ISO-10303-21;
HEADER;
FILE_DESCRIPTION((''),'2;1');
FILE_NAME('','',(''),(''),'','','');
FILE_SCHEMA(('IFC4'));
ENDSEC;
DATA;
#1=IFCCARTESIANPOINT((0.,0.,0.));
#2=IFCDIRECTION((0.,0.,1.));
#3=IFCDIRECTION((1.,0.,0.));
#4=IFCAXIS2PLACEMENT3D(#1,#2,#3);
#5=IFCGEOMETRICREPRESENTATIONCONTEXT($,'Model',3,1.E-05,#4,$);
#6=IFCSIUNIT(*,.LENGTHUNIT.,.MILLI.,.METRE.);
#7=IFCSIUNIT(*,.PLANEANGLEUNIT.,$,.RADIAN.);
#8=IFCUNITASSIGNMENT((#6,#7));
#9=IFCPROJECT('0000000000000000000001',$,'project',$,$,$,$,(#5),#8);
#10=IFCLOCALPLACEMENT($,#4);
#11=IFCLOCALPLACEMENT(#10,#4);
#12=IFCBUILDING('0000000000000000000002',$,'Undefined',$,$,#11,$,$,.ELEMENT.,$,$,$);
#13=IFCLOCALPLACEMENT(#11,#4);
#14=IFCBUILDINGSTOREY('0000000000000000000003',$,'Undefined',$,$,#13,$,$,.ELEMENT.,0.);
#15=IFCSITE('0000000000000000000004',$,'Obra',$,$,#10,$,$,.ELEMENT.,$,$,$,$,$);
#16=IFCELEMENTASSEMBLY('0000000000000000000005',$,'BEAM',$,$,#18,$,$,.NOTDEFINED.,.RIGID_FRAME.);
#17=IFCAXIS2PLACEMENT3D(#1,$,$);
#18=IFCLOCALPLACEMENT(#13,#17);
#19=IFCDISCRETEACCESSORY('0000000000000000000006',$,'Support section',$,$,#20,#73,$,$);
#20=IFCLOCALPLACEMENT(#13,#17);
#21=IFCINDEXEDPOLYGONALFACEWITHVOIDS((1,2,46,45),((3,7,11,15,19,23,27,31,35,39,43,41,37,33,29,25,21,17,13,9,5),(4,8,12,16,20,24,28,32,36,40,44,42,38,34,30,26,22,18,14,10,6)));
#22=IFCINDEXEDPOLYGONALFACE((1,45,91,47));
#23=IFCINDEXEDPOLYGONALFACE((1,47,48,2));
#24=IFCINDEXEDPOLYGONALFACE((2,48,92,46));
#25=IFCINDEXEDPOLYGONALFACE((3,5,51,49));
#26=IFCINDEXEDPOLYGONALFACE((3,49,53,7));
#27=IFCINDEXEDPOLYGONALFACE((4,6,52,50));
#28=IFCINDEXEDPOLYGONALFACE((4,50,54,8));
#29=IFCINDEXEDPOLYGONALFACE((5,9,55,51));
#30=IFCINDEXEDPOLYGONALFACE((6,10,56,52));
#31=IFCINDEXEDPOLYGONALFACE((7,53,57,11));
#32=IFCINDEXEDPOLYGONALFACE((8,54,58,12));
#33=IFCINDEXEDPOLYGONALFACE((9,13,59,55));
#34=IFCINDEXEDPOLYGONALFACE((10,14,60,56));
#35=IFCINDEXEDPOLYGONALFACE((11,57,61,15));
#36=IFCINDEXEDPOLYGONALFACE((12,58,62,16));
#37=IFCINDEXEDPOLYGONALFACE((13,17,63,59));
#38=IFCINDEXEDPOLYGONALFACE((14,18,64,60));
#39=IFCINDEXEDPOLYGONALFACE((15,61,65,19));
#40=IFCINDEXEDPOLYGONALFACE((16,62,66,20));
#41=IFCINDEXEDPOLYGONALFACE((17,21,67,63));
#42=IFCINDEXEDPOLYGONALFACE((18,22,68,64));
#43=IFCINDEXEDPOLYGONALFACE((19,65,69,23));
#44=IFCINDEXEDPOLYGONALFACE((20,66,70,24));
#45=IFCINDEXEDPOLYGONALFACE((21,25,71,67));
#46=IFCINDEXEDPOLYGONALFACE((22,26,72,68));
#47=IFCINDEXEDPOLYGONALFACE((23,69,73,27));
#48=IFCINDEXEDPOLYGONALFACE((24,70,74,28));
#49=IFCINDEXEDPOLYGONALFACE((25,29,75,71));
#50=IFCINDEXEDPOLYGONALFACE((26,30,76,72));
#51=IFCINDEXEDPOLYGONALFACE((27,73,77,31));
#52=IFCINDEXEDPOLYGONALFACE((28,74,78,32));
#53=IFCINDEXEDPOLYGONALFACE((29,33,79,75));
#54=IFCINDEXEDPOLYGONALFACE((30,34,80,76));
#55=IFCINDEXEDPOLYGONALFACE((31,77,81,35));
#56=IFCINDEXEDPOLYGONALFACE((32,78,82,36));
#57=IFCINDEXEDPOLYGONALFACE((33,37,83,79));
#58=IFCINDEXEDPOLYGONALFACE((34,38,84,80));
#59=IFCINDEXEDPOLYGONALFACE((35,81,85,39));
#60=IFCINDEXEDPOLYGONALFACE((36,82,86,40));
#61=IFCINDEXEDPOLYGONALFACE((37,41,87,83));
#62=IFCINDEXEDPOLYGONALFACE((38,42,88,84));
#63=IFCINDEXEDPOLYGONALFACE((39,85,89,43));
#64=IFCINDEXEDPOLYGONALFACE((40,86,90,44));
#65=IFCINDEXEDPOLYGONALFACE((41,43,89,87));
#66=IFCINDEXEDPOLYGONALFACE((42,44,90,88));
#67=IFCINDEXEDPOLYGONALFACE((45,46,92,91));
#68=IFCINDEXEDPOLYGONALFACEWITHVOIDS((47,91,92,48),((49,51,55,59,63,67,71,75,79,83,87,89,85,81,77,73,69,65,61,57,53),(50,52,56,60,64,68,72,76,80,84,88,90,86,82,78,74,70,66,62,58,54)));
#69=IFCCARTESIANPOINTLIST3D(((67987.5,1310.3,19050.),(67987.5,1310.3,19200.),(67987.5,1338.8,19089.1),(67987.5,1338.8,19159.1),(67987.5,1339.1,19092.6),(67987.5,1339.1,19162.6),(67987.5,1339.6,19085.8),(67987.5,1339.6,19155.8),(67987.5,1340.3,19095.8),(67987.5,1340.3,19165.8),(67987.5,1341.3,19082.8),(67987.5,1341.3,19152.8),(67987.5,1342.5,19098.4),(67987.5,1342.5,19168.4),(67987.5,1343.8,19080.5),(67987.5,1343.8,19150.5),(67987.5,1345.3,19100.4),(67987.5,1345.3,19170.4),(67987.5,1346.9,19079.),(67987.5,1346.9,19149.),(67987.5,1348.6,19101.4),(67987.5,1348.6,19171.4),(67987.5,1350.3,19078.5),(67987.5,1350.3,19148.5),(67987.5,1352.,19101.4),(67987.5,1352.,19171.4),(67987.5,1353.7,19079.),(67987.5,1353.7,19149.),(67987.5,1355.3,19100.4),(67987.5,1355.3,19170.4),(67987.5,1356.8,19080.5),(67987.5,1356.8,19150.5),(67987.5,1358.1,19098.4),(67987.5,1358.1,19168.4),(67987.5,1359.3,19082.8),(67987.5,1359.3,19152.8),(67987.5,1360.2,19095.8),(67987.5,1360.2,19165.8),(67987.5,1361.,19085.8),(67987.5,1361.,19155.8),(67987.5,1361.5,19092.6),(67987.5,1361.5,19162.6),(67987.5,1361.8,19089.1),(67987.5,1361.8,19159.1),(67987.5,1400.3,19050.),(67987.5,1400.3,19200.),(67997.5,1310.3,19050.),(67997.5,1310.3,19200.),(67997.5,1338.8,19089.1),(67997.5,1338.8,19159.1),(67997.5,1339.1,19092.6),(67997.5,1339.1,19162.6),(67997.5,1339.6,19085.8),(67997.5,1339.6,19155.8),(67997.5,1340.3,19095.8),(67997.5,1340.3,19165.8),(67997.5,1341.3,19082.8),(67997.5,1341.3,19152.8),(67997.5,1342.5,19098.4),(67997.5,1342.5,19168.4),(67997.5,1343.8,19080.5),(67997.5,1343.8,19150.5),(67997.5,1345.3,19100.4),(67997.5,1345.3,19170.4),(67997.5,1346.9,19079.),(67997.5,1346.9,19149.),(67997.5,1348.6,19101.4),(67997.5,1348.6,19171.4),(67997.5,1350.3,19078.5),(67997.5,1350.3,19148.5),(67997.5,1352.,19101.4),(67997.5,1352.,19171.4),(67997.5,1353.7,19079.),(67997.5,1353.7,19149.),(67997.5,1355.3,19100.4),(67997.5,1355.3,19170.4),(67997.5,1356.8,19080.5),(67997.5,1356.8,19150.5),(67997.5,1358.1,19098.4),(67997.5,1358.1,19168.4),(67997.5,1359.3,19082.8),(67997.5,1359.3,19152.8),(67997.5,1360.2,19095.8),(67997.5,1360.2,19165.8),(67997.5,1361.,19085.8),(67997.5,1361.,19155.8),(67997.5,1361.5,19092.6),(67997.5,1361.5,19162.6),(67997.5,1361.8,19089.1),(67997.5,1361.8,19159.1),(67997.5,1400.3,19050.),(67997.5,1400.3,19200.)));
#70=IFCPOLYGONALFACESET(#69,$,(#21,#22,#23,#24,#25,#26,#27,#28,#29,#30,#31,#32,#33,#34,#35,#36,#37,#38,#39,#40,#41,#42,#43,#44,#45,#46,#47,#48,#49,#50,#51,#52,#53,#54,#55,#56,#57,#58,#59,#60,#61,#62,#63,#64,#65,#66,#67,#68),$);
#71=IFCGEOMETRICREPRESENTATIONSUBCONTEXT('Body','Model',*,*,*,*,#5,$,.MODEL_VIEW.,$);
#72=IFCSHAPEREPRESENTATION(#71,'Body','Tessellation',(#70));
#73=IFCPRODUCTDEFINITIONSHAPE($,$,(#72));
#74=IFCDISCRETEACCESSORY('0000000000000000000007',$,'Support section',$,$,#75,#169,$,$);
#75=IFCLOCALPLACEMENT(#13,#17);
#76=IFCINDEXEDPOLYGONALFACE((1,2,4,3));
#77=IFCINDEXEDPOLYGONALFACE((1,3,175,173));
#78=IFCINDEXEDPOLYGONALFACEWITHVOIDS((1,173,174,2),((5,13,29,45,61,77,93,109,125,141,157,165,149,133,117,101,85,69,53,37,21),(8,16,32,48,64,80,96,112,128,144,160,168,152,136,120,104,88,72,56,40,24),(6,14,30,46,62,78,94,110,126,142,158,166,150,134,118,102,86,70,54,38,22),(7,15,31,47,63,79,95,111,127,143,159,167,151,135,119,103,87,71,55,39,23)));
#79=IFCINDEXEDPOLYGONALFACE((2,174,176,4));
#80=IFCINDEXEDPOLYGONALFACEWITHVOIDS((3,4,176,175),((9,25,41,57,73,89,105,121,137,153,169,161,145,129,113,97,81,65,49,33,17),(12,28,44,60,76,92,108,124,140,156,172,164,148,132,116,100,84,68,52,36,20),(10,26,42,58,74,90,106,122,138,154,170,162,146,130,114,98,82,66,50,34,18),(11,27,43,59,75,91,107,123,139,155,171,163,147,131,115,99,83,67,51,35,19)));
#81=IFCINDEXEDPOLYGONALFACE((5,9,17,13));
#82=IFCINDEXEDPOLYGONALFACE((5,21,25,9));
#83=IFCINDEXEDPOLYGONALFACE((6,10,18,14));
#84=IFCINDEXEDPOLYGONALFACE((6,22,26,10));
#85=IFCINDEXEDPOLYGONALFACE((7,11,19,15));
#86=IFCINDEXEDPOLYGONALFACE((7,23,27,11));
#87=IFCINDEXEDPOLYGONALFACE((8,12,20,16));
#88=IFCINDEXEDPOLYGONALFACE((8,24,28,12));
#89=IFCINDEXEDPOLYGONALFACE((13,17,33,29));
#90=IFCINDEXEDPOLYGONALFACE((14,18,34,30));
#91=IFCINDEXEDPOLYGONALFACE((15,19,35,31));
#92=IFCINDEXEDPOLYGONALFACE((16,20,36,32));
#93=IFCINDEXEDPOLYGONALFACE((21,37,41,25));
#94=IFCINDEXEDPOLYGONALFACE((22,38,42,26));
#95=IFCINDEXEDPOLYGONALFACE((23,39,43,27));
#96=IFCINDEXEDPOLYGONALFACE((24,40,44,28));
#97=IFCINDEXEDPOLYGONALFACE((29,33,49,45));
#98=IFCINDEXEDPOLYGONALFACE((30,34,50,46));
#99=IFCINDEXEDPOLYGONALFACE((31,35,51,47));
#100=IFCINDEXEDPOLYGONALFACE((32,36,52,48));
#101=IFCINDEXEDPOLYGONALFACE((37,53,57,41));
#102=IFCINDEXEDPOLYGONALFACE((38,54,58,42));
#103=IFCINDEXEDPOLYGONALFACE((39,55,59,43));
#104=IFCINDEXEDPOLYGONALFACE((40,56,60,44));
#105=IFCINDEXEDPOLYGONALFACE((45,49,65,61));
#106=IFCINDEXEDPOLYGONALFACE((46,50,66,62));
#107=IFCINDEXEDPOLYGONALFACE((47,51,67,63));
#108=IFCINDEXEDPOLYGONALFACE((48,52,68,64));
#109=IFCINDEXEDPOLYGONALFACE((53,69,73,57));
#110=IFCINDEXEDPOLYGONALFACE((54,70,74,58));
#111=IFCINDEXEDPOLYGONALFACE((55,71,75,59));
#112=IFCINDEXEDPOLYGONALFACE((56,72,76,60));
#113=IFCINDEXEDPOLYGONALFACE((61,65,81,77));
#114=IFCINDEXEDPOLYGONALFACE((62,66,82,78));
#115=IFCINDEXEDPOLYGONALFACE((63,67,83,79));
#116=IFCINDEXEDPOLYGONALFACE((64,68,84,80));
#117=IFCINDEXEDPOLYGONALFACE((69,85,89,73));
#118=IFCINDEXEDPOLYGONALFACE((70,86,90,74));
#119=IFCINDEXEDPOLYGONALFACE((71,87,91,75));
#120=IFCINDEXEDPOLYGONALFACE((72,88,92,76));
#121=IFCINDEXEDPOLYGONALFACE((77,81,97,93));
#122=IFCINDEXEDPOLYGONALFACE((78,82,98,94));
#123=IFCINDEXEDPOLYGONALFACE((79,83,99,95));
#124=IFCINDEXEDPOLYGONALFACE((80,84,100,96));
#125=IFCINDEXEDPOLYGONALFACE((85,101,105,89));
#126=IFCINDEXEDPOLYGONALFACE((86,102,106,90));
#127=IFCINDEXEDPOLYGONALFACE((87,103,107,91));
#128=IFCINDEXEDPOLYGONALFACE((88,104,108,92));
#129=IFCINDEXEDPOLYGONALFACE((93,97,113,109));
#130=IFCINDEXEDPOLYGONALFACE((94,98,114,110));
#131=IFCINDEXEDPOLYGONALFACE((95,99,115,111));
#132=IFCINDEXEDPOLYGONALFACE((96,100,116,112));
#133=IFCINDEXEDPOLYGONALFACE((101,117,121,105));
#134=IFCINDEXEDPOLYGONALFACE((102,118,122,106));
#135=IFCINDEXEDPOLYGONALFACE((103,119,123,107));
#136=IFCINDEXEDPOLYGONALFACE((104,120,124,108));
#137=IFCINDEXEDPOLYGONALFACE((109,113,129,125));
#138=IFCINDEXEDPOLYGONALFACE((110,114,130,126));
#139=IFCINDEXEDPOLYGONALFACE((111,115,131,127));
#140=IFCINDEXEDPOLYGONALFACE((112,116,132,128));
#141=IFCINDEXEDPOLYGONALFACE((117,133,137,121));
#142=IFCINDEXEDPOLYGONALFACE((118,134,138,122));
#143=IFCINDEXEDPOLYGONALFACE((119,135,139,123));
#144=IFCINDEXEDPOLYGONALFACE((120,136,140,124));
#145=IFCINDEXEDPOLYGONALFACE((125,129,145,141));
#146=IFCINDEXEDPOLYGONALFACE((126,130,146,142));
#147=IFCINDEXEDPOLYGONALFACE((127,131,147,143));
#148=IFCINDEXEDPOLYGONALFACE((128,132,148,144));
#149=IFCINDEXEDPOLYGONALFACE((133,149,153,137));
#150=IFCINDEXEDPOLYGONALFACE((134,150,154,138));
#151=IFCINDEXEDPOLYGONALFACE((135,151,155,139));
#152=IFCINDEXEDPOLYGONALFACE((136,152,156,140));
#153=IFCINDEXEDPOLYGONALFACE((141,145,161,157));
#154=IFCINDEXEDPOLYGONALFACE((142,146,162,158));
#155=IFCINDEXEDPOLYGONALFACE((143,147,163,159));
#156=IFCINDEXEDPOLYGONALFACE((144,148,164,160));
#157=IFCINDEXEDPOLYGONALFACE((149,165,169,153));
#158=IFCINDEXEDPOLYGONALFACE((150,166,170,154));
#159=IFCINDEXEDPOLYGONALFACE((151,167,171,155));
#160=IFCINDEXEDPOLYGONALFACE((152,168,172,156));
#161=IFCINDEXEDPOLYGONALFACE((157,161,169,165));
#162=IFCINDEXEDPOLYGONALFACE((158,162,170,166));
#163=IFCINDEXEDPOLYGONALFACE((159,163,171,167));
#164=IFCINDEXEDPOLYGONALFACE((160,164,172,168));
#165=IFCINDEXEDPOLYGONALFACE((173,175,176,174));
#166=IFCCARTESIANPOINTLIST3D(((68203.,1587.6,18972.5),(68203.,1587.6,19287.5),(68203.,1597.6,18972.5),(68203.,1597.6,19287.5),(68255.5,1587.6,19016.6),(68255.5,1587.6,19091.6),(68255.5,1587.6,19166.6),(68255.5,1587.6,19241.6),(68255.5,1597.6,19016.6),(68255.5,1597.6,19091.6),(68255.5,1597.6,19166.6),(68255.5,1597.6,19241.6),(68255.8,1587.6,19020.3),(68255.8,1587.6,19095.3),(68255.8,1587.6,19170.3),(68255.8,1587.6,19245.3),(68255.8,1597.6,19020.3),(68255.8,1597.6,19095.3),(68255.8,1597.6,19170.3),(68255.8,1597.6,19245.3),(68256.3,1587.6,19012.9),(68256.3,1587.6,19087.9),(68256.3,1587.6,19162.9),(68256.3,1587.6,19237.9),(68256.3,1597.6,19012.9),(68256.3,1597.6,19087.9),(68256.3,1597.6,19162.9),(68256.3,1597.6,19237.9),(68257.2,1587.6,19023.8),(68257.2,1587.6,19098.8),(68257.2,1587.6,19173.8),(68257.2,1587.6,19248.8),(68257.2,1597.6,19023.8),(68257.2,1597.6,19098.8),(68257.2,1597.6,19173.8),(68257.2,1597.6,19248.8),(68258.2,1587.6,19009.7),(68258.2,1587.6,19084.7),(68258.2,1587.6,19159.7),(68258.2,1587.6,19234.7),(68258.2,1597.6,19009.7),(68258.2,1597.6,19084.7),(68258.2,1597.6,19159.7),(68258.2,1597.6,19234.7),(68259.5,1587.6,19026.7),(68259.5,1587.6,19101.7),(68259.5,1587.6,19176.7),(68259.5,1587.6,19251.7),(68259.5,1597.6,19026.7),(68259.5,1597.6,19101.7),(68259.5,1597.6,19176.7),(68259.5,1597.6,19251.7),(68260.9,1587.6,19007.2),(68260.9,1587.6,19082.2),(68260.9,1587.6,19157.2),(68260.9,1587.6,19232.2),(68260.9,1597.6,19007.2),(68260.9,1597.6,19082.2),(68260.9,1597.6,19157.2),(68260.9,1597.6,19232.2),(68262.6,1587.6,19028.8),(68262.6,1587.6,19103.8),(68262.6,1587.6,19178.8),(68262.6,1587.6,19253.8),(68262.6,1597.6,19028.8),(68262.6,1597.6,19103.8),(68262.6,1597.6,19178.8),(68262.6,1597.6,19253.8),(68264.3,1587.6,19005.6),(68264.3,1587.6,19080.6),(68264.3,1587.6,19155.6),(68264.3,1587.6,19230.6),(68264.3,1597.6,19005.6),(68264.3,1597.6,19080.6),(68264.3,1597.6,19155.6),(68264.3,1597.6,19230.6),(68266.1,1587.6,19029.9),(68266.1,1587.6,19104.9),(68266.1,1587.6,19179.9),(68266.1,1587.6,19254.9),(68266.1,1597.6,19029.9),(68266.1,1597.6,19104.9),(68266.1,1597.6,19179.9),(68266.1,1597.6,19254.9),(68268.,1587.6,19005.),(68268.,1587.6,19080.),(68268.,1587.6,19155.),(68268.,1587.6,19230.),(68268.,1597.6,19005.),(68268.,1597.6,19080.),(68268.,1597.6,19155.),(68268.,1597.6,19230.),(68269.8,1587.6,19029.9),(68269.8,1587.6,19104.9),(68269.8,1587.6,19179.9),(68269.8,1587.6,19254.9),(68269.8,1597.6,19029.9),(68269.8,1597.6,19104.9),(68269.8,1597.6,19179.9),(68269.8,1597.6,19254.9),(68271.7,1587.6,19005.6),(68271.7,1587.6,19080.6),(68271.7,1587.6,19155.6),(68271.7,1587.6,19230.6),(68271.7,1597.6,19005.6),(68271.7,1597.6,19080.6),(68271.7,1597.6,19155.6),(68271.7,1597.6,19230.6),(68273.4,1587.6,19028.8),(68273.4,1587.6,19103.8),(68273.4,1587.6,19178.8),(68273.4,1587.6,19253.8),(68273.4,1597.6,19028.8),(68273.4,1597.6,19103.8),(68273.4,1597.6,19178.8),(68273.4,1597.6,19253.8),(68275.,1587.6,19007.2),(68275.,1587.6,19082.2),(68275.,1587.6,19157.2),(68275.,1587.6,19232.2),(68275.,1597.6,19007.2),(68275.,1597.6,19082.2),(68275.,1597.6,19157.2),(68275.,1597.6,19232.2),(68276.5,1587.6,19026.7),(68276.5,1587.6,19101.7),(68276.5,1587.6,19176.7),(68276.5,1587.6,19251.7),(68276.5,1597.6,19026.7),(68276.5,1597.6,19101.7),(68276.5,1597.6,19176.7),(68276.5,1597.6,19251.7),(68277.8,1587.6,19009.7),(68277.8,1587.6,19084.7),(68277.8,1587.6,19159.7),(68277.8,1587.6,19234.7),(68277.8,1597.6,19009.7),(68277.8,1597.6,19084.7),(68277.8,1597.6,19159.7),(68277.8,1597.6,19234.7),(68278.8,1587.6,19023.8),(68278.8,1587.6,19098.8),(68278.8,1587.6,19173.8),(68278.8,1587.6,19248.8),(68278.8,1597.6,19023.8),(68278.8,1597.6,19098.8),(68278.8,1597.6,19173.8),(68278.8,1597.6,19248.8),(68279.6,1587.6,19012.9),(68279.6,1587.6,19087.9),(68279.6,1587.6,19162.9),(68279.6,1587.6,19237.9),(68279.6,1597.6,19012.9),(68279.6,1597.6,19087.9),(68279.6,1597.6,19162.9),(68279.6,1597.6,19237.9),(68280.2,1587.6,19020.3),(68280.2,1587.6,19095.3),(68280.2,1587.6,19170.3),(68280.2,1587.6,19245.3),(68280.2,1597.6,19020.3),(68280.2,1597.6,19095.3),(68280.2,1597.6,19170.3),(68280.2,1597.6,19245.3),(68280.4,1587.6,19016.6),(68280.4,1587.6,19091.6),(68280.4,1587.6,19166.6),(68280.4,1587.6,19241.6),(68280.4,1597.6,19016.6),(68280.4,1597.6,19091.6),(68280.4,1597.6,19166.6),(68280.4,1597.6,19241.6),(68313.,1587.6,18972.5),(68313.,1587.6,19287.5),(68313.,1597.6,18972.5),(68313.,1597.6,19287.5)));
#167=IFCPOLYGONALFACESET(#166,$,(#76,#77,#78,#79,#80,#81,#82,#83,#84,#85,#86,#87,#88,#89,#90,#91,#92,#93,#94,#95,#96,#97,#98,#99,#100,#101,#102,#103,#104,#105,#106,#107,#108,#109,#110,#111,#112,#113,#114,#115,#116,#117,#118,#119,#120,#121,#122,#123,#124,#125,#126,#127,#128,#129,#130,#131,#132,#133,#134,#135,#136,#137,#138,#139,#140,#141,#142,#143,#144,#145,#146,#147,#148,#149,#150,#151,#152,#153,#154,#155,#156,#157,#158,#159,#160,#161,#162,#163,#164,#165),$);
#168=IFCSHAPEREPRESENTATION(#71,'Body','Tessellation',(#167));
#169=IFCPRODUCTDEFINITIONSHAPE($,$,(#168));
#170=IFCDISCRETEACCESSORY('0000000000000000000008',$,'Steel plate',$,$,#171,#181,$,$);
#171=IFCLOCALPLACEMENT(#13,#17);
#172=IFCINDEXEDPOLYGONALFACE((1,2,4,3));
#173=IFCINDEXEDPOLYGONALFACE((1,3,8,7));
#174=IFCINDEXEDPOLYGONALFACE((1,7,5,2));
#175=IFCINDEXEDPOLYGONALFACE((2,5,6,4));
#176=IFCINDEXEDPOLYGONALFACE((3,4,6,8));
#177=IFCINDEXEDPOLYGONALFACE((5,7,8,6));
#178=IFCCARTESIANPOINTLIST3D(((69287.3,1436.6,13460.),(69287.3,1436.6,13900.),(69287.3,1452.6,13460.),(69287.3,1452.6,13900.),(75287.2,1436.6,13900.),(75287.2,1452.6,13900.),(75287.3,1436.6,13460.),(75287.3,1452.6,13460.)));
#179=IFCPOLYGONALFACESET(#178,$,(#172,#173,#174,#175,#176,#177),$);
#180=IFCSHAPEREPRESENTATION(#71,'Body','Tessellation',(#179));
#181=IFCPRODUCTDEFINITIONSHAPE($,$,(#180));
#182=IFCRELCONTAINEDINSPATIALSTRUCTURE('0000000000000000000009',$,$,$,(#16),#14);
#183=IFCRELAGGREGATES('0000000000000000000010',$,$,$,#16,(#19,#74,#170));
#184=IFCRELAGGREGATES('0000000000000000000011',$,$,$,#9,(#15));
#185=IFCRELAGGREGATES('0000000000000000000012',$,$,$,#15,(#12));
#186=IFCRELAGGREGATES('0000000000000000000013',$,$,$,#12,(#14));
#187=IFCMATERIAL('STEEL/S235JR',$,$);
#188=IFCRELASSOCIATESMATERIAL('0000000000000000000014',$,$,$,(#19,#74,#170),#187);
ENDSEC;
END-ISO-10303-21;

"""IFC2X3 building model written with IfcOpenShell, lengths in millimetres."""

from ifc_helpers import new_model, si_unit, frame, origin_with_axes, origin_2d_with_axis, place, context, subcontext, project, spatial, polyline, rectangle, circle, outline, extrude, source, transform, mapped, material, element, aggregate, save


model = new_model("IFC2X3")

# Units and contexts
model_context = context("Model", 3, precision=1e-05, world=origin_with_axes())
body_context = subcontext(model_context, "Body", "Model", "MODEL_VIEW")
ifc_project = project(units=[si_unit("LENGTHUNIT", "METRE", prefix="MILLI"), si_unit("PLANEANGLEUNIT", "RADIAN")], contexts=[model_context])

# Site, building, storey
site_placement = place(None, origin_with_axes())
site = spatial("IfcSite", under=ifc_project, at=site_placement, Name="Obra", CompositionType="ELEMENT")
building_placement = place(site_placement, origin_with_axes())
building = spatial("IfcBuilding", under=site, at=building_placement, Name="Undefined", CompositionType="ELEMENT")
storey_placement = place(building_placement, origin_with_axes())
storey = spatial("IfcBuildingStorey", under=building, at=storey_placement, Name="Undefined", CompositionType="ELEMENT", Elevation=0.0)

# Element assembly
assembly_1_placement = place(storey_placement, origin_with_axes())
assembly_1 = element("IfcElementAssembly", 1, at=assembly_1_placement, inside=storey, Name="BEAM", AssemblyPlace="NOTDEFINED", PredefinedType="RIGID_FRAME")

# Shared definitions
ifc_material_1 = material(Name="STEEL/S235JR")

# Discrete accessories, openings
shared_shape_1 = source(origin_with_axes(), body_context, "Body", "SweptSolid", [
    extrude(circle(Radius=11.5, at=origin_2d_with_axis()), frame((0.0, -12.6, 0.0), z_axis=(0.0, 1.0, 0.0), x_axis=(1.0, 0.0, 0.0)), (0.0, 0.0, 1.0), 10.2),
])
discrete_accessory_1_placement = place(assembly_1_placement, frame((67992.5, 1355.3, 19050.0), z_axis=(0.0, 0.0, 1.0), x_axis=(0.0, 1.0, 0.0)))
discrete_accessory_1 = element("IfcDiscreteAccessory", 2, at=discrete_accessory_1_placement, material=ifc_material_1, Name="Support section", context=body_context, shape_type="SweptSolid", body=[
    extrude(rectangle(XDim=10.0, YDim=90.0, at=origin_2d_with_axis()), frame((0.0, 0.0, 150.0), z_axis=(0.0, 0.0, -1.0), x_axis=(0.0, 1.0, 0.0)), (0.0, 0.0, 1.0), 150.0),
])
opening_1_placement = place(assembly_1_placement, frame((68000.0, 1390.3, 19205.0), z_axis=(0.0, -1.0, 0.0), x_axis=(0.0, 0.0, -1.0)))
element("IfcOpeningElement", 3, at=opening_1_placement, cuts=discrete_accessory_1, ObjectType="Opening", context=body_context, shape_type="MappedRepresentation", body=[
    mapped(shared_shape_1, transform((45.0, 0.0, 40.0))),
    mapped(shared_shape_1, transform((115.0, 0.0, 40.0))),
])
discrete_accessory_2_placement = place(assembly_1_placement, frame((68258.0, 1592.6, 18972.5), z_axis=(0.0, 0.0, 1.0), x_axis=(-1.0, 0.0, 0.0)))
discrete_accessory_2 = element("IfcDiscreteAccessory", 4, at=discrete_accessory_2_placement, material=ifc_material_1, Name="Support section", context=body_context, shape_type="SweptSolid", body=[
    extrude(rectangle(XDim=10.0, YDim=110.0, at=origin_2d_with_axis()), frame((0.0, 0.0, 315.0), z_axis=(0.0, 0.0, -1.0), x_axis=(0.0, 1.0, 0.0)), (0.0, 0.0, 1.0), 315.0),
])
shared_shape_2 = source(origin_with_axes(), body_context, "Body", "SweptSolid", [
    extrude(circle(Radius=12.5, at=origin_2d_with_axis()), frame((0.0, -15.8, 0.0), z_axis=(0.0, 1.0, 0.0), x_axis=(1.0, 0.0, 0.0)), (0.0, 0.0, 1.0), 10.2),
])
opening_2_placement = place(assembly_1_placement, frame((68223.0, 1603.4, 19350.0), z_axis=(1.0, 0.0, 0.0), x_axis=(0.0, 0.0, -1.0)))
element("IfcOpeningElement", 5, at=opening_2_placement, cuts=discrete_accessory_2, ObjectType="Opening", context=body_context, shape_type="MappedRepresentation", body=[
    mapped(shared_shape_2, transform((107.5, 0.0, 45.0))),
    mapped(shared_shape_2, transform((182.5, 0.0, 45.0))),
    mapped(shared_shape_2, transform((257.5, 0.0, 45.0))),
    mapped(shared_shape_2, transform((332.5, 0.0, 45.0))),
])

# Discrete accessory
discrete_accessory_3_placement = place(assembly_1_placement, frame((69287.3, 1444.6, 13900.0), z_axis=(0.0, -1.0, 0.0), x_axis=(0.0, 0.0, -1.0)))
discrete_accessory_3 = element("IfcDiscreteAccessory", 6, at=discrete_accessory_3_placement, material=ifc_material_1, Name="Steel plate", context=body_context, shape_type="SweptSolid", body=[
    extrude(outline(polyline([(0.0, 0.0), (440.0, 0.0), (440.0, 6000.0), (0.0, 5999.9), (0.0, 0.0)])), frame((0.0, 0.0, -8.0), z_axis=(0.0, 0.0, 1.0), x_axis=(1.0, 0.0, 0.0)), (0.0, 0.0, 1.0), 16.0),
])
aggregate(assembly_1, [discrete_accessory_1, discrete_accessory_2, discrete_accessory_3])

save(model, "model.ifc")
